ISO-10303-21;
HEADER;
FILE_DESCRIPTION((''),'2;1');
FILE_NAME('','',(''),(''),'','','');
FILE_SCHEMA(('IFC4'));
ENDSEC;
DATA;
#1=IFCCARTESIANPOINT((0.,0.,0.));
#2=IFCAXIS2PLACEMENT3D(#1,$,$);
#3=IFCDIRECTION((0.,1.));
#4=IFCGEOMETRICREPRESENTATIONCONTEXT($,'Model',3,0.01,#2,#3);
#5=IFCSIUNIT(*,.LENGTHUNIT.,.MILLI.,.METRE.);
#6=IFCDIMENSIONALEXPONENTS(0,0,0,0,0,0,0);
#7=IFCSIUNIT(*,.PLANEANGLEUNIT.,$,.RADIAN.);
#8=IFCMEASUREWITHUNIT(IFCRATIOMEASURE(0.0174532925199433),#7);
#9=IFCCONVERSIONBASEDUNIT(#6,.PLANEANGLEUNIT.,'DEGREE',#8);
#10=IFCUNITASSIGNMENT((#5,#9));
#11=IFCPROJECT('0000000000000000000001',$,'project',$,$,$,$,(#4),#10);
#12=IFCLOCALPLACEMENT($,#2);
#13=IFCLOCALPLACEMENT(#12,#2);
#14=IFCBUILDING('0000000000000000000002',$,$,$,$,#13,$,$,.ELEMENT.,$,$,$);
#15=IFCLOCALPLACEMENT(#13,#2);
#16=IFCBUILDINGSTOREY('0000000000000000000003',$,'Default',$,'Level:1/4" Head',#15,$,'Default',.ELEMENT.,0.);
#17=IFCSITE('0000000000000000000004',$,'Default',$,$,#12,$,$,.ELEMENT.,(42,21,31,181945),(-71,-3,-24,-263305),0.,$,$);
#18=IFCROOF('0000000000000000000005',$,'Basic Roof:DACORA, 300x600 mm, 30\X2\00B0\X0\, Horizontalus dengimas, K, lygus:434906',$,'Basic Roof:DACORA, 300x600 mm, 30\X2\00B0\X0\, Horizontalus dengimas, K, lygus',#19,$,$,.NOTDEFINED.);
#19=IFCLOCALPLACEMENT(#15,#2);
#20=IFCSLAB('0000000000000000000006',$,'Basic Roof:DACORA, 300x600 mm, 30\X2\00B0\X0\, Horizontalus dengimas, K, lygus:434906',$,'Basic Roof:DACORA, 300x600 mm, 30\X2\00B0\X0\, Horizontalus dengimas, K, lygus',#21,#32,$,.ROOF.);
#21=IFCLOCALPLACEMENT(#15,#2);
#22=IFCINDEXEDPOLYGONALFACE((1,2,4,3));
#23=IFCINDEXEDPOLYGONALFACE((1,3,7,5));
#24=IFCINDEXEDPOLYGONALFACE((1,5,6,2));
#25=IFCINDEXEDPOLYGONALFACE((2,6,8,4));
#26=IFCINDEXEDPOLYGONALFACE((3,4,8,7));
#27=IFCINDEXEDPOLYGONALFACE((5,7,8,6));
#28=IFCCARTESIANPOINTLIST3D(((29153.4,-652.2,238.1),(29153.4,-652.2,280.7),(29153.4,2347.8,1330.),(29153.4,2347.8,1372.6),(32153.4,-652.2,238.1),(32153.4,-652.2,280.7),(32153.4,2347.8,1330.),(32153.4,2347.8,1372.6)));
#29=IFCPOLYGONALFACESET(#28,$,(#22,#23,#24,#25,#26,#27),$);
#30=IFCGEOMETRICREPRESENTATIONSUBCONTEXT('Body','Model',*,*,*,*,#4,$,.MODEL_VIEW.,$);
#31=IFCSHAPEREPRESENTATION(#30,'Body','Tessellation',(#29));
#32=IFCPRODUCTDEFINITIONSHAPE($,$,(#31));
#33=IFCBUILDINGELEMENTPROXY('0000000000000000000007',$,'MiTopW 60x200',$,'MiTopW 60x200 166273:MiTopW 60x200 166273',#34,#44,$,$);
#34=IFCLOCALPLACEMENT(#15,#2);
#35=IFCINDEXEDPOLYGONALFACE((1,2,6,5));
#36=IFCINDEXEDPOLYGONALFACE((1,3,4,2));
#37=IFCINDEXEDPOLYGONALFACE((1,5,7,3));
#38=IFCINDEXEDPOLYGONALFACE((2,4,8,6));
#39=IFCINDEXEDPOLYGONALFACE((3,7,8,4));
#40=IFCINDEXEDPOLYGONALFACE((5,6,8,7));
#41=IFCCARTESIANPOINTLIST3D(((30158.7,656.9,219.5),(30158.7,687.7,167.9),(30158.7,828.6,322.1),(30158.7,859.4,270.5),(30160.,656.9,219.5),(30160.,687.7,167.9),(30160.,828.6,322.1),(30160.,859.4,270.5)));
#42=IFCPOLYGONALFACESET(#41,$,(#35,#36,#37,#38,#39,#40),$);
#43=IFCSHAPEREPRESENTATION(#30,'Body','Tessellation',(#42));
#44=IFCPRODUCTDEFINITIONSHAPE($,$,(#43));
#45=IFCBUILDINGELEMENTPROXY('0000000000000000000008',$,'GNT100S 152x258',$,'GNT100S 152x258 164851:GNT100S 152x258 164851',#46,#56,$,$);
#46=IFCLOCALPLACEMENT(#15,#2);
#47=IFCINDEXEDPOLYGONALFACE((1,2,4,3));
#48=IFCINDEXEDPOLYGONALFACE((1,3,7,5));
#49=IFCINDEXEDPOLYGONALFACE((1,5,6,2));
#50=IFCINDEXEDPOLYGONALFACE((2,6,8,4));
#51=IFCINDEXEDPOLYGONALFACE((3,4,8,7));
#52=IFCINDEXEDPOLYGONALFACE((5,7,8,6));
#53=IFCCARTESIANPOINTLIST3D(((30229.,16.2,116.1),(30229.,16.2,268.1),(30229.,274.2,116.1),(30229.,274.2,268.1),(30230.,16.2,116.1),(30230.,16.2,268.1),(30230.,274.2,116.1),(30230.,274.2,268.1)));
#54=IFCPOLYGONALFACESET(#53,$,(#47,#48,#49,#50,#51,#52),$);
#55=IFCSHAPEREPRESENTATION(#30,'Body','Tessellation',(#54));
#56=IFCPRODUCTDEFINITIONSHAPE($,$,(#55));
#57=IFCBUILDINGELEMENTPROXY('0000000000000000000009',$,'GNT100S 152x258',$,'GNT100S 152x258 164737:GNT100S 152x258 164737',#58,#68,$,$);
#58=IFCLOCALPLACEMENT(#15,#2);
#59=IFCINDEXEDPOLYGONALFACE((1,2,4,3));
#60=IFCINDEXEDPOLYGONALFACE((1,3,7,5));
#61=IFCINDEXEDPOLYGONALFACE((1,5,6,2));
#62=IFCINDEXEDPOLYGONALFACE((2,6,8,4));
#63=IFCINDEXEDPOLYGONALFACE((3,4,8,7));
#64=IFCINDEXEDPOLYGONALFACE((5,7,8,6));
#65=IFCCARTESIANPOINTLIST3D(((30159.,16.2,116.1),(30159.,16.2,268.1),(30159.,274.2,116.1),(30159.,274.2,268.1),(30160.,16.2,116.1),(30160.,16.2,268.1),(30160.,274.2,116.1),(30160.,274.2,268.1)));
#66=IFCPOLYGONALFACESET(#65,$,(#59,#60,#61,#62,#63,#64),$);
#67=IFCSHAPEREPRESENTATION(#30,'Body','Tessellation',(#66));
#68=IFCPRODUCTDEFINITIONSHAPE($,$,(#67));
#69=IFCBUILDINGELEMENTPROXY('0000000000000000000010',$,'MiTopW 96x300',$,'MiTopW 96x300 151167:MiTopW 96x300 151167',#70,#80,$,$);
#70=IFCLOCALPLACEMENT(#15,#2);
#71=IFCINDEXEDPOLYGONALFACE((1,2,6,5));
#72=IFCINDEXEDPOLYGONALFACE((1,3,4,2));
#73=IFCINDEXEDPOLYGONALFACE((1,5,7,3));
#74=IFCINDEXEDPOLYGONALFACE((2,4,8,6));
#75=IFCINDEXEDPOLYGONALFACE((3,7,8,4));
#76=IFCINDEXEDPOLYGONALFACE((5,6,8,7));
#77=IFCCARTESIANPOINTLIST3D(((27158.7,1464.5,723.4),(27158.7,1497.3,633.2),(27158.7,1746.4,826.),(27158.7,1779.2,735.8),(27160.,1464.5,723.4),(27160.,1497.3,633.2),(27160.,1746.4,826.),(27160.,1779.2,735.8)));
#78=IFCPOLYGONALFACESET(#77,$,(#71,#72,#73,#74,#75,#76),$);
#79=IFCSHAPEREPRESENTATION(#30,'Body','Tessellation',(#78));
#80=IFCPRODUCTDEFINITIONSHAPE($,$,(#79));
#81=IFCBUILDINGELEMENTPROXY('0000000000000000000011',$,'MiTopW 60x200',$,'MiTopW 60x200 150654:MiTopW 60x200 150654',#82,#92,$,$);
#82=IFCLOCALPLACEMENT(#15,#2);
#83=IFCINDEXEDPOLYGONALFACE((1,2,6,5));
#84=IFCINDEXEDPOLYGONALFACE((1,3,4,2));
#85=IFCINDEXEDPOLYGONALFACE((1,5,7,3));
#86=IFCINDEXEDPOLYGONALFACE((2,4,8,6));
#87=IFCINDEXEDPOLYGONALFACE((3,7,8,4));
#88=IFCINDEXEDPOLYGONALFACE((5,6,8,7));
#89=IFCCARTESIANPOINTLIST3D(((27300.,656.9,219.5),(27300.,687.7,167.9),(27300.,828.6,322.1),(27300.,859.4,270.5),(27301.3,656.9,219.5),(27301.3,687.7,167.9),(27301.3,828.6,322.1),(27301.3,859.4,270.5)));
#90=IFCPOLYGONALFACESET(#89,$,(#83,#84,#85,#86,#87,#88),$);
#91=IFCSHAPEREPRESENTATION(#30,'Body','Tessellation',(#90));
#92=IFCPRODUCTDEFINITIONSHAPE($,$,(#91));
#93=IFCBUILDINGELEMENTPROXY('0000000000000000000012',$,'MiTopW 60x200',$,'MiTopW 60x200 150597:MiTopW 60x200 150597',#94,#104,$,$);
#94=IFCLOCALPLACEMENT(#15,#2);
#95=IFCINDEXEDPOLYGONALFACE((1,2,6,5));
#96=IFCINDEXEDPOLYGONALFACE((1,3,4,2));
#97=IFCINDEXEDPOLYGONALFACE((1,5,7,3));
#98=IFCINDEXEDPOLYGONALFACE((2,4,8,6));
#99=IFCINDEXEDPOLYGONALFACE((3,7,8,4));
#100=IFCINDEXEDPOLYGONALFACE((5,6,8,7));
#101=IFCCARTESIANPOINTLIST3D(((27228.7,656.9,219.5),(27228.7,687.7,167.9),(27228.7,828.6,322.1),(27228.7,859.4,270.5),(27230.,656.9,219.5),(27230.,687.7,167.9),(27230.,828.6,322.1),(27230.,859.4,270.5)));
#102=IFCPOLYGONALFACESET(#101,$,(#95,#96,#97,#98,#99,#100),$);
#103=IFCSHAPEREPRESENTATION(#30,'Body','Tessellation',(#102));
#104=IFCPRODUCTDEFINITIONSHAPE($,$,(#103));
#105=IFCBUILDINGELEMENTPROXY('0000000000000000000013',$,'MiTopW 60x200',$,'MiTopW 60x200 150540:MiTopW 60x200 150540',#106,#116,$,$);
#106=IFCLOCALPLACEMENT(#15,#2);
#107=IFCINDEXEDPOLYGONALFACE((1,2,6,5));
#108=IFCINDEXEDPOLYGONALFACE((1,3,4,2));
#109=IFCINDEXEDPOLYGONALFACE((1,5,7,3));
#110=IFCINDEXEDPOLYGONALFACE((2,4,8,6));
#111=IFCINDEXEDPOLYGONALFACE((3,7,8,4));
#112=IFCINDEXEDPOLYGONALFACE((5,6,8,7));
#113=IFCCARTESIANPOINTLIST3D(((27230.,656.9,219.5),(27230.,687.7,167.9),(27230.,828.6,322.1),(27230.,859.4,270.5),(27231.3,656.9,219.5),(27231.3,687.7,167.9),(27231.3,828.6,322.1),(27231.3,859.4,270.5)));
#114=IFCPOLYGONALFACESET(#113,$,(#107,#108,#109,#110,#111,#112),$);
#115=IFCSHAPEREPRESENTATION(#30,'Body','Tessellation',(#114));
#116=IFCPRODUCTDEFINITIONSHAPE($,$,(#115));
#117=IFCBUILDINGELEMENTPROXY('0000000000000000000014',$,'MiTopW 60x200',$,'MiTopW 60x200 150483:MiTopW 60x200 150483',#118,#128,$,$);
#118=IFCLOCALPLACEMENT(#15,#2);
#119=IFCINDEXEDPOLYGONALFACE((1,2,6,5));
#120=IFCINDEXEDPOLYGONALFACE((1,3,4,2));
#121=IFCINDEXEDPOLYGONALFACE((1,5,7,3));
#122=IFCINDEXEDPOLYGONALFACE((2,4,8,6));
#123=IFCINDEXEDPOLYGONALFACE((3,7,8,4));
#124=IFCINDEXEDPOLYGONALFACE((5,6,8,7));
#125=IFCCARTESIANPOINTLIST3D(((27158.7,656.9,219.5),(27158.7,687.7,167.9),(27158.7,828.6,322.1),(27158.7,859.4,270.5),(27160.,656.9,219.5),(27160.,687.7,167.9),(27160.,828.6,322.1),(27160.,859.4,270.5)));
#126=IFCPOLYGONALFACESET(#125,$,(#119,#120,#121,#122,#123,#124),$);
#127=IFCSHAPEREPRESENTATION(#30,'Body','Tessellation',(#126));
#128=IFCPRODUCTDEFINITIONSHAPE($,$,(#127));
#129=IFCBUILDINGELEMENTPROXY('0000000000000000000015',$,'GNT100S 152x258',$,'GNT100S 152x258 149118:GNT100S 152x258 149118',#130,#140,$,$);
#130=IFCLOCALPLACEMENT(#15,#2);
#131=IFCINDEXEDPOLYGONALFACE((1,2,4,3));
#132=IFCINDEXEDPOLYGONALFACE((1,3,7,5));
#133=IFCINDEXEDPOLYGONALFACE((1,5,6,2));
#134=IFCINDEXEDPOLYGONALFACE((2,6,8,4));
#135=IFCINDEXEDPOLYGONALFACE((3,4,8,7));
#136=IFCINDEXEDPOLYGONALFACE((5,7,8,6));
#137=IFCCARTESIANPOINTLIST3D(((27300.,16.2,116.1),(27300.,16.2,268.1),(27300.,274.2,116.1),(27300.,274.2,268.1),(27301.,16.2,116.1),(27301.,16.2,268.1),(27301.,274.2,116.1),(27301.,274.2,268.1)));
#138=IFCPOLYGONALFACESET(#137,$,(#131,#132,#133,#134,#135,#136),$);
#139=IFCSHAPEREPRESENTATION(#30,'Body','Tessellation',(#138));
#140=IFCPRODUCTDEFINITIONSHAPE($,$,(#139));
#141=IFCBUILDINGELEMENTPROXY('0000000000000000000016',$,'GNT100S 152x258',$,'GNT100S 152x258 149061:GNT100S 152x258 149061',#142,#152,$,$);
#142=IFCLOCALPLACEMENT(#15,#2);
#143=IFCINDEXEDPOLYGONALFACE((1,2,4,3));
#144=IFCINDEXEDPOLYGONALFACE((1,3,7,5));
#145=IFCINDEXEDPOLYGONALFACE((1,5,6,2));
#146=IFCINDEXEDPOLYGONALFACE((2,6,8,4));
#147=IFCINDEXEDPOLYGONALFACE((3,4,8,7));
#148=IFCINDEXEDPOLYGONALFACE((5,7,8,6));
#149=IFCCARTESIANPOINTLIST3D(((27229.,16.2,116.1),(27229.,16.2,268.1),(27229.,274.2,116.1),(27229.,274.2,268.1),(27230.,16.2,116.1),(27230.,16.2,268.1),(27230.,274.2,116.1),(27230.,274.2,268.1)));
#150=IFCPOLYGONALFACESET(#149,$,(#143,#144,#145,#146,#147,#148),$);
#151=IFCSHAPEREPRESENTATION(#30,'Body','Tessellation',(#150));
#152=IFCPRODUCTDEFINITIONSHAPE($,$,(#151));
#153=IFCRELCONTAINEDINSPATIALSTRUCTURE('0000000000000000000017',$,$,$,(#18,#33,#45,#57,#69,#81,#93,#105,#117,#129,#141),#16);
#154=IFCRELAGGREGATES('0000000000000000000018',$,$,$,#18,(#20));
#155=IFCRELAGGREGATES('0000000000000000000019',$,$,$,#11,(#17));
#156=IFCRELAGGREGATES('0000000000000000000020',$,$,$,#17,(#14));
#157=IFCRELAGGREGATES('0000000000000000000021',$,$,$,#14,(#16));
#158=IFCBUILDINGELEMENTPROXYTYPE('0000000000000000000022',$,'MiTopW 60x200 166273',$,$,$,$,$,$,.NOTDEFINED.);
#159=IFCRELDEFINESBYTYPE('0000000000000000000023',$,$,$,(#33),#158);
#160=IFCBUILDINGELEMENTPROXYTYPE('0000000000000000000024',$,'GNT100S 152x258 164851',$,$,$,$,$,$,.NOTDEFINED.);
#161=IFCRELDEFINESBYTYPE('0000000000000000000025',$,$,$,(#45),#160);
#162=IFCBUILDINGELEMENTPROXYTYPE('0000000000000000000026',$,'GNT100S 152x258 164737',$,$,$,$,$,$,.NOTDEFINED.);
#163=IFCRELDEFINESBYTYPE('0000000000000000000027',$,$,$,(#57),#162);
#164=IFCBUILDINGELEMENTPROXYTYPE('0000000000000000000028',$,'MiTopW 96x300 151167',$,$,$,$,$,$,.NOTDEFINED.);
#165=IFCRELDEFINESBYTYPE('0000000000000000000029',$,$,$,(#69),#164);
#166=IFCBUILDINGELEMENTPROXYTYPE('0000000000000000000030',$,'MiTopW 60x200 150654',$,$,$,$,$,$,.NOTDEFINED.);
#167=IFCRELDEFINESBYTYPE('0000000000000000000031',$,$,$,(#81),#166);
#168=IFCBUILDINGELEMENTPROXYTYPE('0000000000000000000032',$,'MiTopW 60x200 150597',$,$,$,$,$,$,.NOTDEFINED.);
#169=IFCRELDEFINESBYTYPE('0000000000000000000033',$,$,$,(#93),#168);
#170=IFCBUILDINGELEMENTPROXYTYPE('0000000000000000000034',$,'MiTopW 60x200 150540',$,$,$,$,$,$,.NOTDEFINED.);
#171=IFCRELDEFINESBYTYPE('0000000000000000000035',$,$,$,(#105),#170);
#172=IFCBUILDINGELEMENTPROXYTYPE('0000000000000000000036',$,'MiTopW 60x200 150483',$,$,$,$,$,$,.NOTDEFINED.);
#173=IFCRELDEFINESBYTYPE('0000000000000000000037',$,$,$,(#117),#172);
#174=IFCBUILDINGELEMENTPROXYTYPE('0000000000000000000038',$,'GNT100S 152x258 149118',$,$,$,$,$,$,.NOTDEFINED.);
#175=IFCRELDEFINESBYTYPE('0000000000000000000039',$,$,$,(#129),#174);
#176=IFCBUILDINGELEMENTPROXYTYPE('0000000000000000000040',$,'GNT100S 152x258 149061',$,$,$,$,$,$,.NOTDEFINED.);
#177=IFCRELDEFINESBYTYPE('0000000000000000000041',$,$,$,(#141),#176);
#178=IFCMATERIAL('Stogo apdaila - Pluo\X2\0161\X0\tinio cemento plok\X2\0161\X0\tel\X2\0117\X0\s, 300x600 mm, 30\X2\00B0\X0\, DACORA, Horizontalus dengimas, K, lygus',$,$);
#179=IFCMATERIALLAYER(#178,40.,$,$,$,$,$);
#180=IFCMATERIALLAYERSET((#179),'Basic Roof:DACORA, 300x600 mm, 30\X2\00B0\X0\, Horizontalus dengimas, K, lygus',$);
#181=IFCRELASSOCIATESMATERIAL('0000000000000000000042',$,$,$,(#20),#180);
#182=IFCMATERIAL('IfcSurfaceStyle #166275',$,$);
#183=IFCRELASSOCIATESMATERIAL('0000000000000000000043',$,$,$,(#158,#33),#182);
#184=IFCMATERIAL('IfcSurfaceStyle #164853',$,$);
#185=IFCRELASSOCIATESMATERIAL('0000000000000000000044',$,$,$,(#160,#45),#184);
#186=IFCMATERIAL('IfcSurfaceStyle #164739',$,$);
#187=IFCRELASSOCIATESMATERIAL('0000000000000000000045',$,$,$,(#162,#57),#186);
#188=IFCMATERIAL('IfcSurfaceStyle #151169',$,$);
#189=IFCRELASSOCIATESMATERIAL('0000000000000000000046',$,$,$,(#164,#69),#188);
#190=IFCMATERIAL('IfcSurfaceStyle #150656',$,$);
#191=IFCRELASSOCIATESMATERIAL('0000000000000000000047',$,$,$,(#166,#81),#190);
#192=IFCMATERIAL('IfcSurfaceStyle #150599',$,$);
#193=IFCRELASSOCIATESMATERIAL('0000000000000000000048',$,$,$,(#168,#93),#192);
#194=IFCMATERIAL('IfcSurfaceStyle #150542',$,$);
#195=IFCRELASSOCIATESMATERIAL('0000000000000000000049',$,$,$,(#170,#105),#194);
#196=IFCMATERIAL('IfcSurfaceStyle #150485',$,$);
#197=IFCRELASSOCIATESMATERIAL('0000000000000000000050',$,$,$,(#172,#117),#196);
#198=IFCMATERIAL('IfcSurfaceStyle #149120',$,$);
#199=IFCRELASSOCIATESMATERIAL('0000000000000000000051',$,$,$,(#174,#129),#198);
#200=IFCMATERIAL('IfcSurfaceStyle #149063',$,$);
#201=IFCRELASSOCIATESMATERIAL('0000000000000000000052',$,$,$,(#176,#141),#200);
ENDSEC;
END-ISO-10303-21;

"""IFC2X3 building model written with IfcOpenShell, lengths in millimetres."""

from ifc_helpers import new_model, entity, si_unit, converted_unit, direction, frame, frame_2d, origin, origin_2d_with_axis, place, context, subcontext, project, spatial, polyline, rectangle, outline, extrude, source, transform, mapped, material, layer, layer_set, type_object, type_shapes, element, aggregate, save


model = new_model("IFC2X3")

# Units and contexts
model_context = context("Model", 3, precision=0.01, world=origin(), true_north=direction((0.0, 1.0)))
body_context = subcontext(model_context, "Body", "Model", "MODEL_VIEW")
ifc_project = project(units=[si_unit("LENGTHUNIT", "METRE", prefix="MILLI"), converted_unit("PLANEANGLEUNIT", "DEGREE", entity("IfcRatioMeasure", 0.0174532925199433), si_unit("PLANEANGLEUNIT", "RADIAN"), dimensions=[0, 0, 0, 0, 0, 0, 0])], contexts=[model_context])

# Site, building, storey
site_placement = place(None, origin())
site = spatial("IfcSite", under=ifc_project, at=site_placement, Name="Default", CompositionType="ELEMENT", RefLatitude=(42, 21, 31, 181945), RefLongitude=(-71, -3, -24, -263305), RefElevation=0.0)
building_placement = place(site_placement, origin())
building = spatial("IfcBuilding", under=site, at=building_placement, CompositionType="ELEMENT")
storey_placement = place(building_placement, origin())
storey = spatial("IfcBuildingStorey", under=building, at=storey_placement, Name="Default", ObjectType="Level:1/4\" Head", LongName="Default", CompositionType="ELEMENT", Elevation=0.0)

# Roof, slab
roof_placement = place(storey_placement, frame((29153.4, -652.2, 238.1)))
roof = element("IfcRoof", 1, at=roof_placement, inside=storey, Name="Basic Roof:DACORA, 300x600 mm, 30°, Horizontalus dengimas, K, lygus:434906", ObjectType="Basic Roof:DACORA, 300x600 mm, 30°, Horizontalus dengimas, K, lygus", ShapeType="NOTDEFINED")
ifc_material_1 = material(Name="Stogo apdaila - Pluoštinio cemento plokštelės, 300x600 mm, 30°, DACORA, Horizontalus dengimas, K, lygus")
ifc_layer = layer(ifc_material_1, 40.0)
ifc_layer_set = layer_set([ifc_layer], Name="Basic Roof:DACORA, 300x600 mm, 30°, Horizontalus dengimas, K, lygus")
slab_placement = place(roof_placement, origin())
slab = element("IfcSlab", 2, at=slab_placement, material=ifc_layer_set, Name="Basic Roof:DACORA, 300x600 mm, 30°, Horizontalus dengimas, K, lygus:434906", ObjectType="Basic Roof:DACORA, 300x600 mm, 30°, Horizontalus dengimas, K, lygus", PredefinedType="ROOF", context=body_context, shape_type="SweptSolid", body=[
    extrude(rectangle(XDim=3192.5, YDim=3000.0, at=frame_2d((0.0, 0.0), x_axis=(0.0, -1.0))), frame((1500.0, 1500.0, 546.0), z_axis=(0.0, -0.34202, 0.939693), x_axis=(1.0, 0.0, 0.0)), (0.0, 0.34202, 0.939693), 42.6),
])
aggregate(roof, [slab])

# Building element proxies
ifc_material_2 = material(Name="IfcSurfaceStyle #166275")
building_element_proxy_type_1 = type_object("IfcBuildingElementProxyType", Name="MiTopW 60x200 166273", PredefinedType="NOTDEFINED", material=ifc_material_2)
shared_shape_1 = source(origin(), body_context, "Body", "SweptSolid", [
    extrude(outline(polyline([(-100.0, -30.0), (100.0, -30.0), (100.0, 30.0), (-100.0, 30.0), (-100.0, -30.0)])), frame((100.0, 30.0, 0.0), z_axis=(0.0, 0.0, 1.0), x_axis=(-1.0, 0.0, 0.0)), (0.0, 0.0, 1.0), 1.3),
])
type_shapes(building_element_proxy_type_1, [shared_shape_1])
proxy_1_placement = place(building_placement, frame((30160.0, 656.9, 219.5), z_axis=(-1.0, 0.0, 0.0), x_axis=(0.0, 0.858392, 0.512994)))
element("IfcBuildingElementProxy", 3, at=proxy_1_placement, inside=storey, type_object=building_element_proxy_type_1, material=ifc_material_2, Name="MiTopW 60x200", ObjectType="MiTopW 60x200 166273:MiTopW 60x200 166273", context=body_context, shape_type="MappedRepresentation", body=[
    mapped(shared_shape_1, transform((0.0, 0.0, 0.0), scale=1.0)),
])
ifc_material_3 = material(Name="IfcSurfaceStyle #164853")
building_element_proxy_type_2 = type_object("IfcBuildingElementProxyType", Name="GNT100S 152x258 164851", PredefinedType="NOTDEFINED", material=ifc_material_3)
shared_shape_2 = source(origin(), body_context, "Body", "SweptSolid", [
    extrude(rectangle(XDim=258.0, YDim=152.0, at=origin_2d_with_axis()), frame((129.0, 76.0, 0.0), z_axis=(0.0, 0.0, 1.0), x_axis=(-1.0, 0.0, 0.0)), (0.0, 0.0, 1.0), 1.0),
])
type_shapes(building_element_proxy_type_2, [shared_shape_2])
proxy_2_placement = place(building_placement, frame((30230.0, 16.2, 268.1), z_axis=(-1.0, 0.0, 0.0), x_axis=(0.0, 1.0, 0.0)))
element("IfcBuildingElementProxy", 4, at=proxy_2_placement, inside=storey, type_object=building_element_proxy_type_2, material=ifc_material_3, Name="GNT100S 152x258", ObjectType="GNT100S 152x258 164851:GNT100S 152x258 164851", context=body_context, shape_type="MappedRepresentation", body=[
    mapped(shared_shape_2, transform((0.0, 0.0, 0.0), scale=1.0)),
])
ifc_material_4 = material(Name="IfcSurfaceStyle #164739")
building_element_proxy_type_3 = type_object("IfcBuildingElementProxyType", Name="GNT100S 152x258 164737", PredefinedType="NOTDEFINED", material=ifc_material_4)
shared_shape_3 = source(origin(), body_context, "Body", "SweptSolid", [
    extrude(rectangle(XDim=258.0, YDim=152.0, at=origin_2d_with_axis()), frame((129.0, 76.0, 0.0), z_axis=(0.0, 0.0, 1.0), x_axis=(-1.0, 0.0, 0.0)), (0.0, 0.0, 1.0), 1.0),
])
type_shapes(building_element_proxy_type_3, [shared_shape_3])
proxy_3_placement = place(building_placement, frame((30160.0, 16.2, 268.1), z_axis=(-1.0, 0.0, 0.0), x_axis=(0.0, 1.0, 0.0)))
element("IfcBuildingElementProxy", 5, at=proxy_3_placement, inside=storey, type_object=building_element_proxy_type_3, material=ifc_material_4, Name="GNT100S 152x258", ObjectType="GNT100S 152x258 164737:GNT100S 152x258 164737", context=body_context, shape_type="MappedRepresentation", body=[
    mapped(shared_shape_3, transform((0.0, 0.0, 0.0), scale=1.0)),
])
ifc_material_5 = material(Name="IfcSurfaceStyle #151169")
building_element_proxy_type_4 = type_object("IfcBuildingElementProxyType", Name="MiTopW 96x300 151167", PredefinedType="NOTDEFINED", material=ifc_material_5)
shared_shape_4 = source(origin(), body_context, "Body", "SweptSolid", [
    extrude(outline(polyline([(-150.0, -48.0), (150.0, -48.0), (150.0, 48.0), (-150.0, 48.0), (-150.0, -48.0)])), frame((150.0, 48.0, 0.0), z_axis=(0.0, 0.0, 1.0), x_axis=(-1.0, 0.0, 0.0)), (0.0, 0.0, 1.0), 1.3),
])
type_shapes(building_element_proxy_type_4, [shared_shape_4])
proxy_4_placement = place(building_placement, frame((27160.0, 1464.5, 723.4), z_axis=(-1.0, 0.0, 0.0), x_axis=(0.0, 0.939693, 0.34202)))
element("IfcBuildingElementProxy", 6, at=proxy_4_placement, inside=storey, type_object=building_element_proxy_type_4, material=ifc_material_5, Name="MiTopW 96x300", ObjectType="MiTopW 96x300 151167:MiTopW 96x300 151167", context=body_context, shape_type="MappedRepresentation", body=[
    mapped(shared_shape_4, transform((0.0, 0.0, 0.0), scale=1.0)),
])
ifc_material_6 = material(Name="IfcSurfaceStyle #150656")
building_element_proxy_type_5 = type_object("IfcBuildingElementProxyType", Name="MiTopW 60x200 150654", PredefinedType="NOTDEFINED", material=ifc_material_6)
shared_shape_5 = source(origin(), body_context, "Body", "SweptSolid", [
    extrude(outline(polyline([(-100.0, -30.0), (100.0, -30.0), (100.0, 30.0), (-100.0, 30.0), (-100.0, -30.0)])), frame((100.0, 30.0, 0.0), z_axis=(0.0, 0.0, 1.0), x_axis=(-1.0, 0.0, 0.0)), (0.0, 0.0, 1.0), 1.3),
])
type_shapes(building_element_proxy_type_5, [shared_shape_5])
proxy_5_placement = place(building_placement, frame((27301.3, 656.9, 219.5), z_axis=(-1.0, 0.0, 0.0), x_axis=(0.0, 0.858392, 0.512994)))
element("IfcBuildingElementProxy", 7, at=proxy_5_placement, inside=storey, type_object=building_element_proxy_type_5, material=ifc_material_6, Name="MiTopW 60x200", ObjectType="MiTopW 60x200 150654:MiTopW 60x200 150654", context=body_context, shape_type="MappedRepresentation", body=[
    mapped(shared_shape_5, transform((0.0, 0.0, 0.0), scale=1.0)),
])
ifc_material_7 = material(Name="IfcSurfaceStyle #150599")
building_element_proxy_type_6 = type_object("IfcBuildingElementProxyType", Name="MiTopW 60x200 150597", PredefinedType="NOTDEFINED", material=ifc_material_7)
shared_shape_6 = source(origin(), body_context, "Body", "SweptSolid", [
    extrude(outline(polyline([(-100.0, -30.0), (100.0, -30.0), (100.0, 30.0), (-100.0, 30.0), (-100.0, -30.0)])), frame((100.0, 30.0, 0.0), z_axis=(0.0, 0.0, 1.0), x_axis=(-1.0, 0.0, 0.0)), (0.0, 0.0, 1.0), 1.3),
])
type_shapes(building_element_proxy_type_6, [shared_shape_6])
proxy_6_placement = place(building_placement, frame((27230.0, 656.9, 219.5), z_axis=(-1.0, 0.0, 0.0), x_axis=(0.0, 0.858392, 0.512994)))
element("IfcBuildingElementProxy", 8, at=proxy_6_placement, inside=storey, type_object=building_element_proxy_type_6, material=ifc_material_7, Name="MiTopW 60x200", ObjectType="MiTopW 60x200 150597:MiTopW 60x200 150597", context=body_context, shape_type="MappedRepresentation", body=[
    mapped(shared_shape_6, transform((0.0, 0.0, 0.0), scale=1.0)),
])
ifc_material_8 = material(Name="IfcSurfaceStyle #150542")
building_element_proxy_type_7 = type_object("IfcBuildingElementProxyType", Name="MiTopW 60x200 150540", PredefinedType="NOTDEFINED", material=ifc_material_8)
shared_shape_7 = source(origin(), body_context, "Body", "SweptSolid", [
    extrude(outline(polyline([(-100.0, -30.0), (100.0, -30.0), (100.0, 30.0), (-100.0, 30.0), (-100.0, -30.0)])), frame((100.0, 30.0, 0.0), z_axis=(0.0, 0.0, 1.0), x_axis=(-1.0, 0.0, 0.0)), (0.0, 0.0, 1.0), 1.3),
])
type_shapes(building_element_proxy_type_7, [shared_shape_7])
proxy_7_placement = place(building_placement, frame((27231.3, 656.9, 219.5), z_axis=(-1.0, 0.0, 0.0), x_axis=(0.0, 0.858392, 0.512994)))
element("IfcBuildingElementProxy", 9, at=proxy_7_placement, inside=storey, type_object=building_element_proxy_type_7, material=ifc_material_8, Name="MiTopW 60x200", ObjectType="MiTopW 60x200 150540:MiTopW 60x200 150540", context=body_context, shape_type="MappedRepresentation", body=[
    mapped(shared_shape_7, transform((0.0, 0.0, 0.0), scale=1.0)),
])
ifc_material_9 = material(Name="IfcSurfaceStyle #150485")
building_element_proxy_type_8 = type_object("IfcBuildingElementProxyType", Name="MiTopW 60x200 150483", PredefinedType="NOTDEFINED", material=ifc_material_9)
shared_shape_8 = source(origin(), body_context, "Body", "SweptSolid", [
    extrude(outline(polyline([(-100.0, -30.0), (100.0, -30.0), (100.0, 30.0), (-100.0, 30.0), (-100.0, -30.0)])), frame((100.0, 30.0, 0.0), z_axis=(0.0, 0.0, 1.0), x_axis=(-1.0, 0.0, 0.0)), (0.0, 0.0, 1.0), 1.3),
])
type_shapes(building_element_proxy_type_8, [shared_shape_8])
proxy_8_placement = place(building_placement, frame((27160.0, 656.9, 219.5), z_axis=(-1.0, 0.0, 0.0), x_axis=(0.0, 0.858392, 0.512994)))
element("IfcBuildingElementProxy", 10, at=proxy_8_placement, inside=storey, type_object=building_element_proxy_type_8, material=ifc_material_9, Name="MiTopW 60x200", ObjectType="MiTopW 60x200 150483:MiTopW 60x200 150483", context=body_context, shape_type="MappedRepresentation", body=[
    mapped(shared_shape_8, transform((0.0, 0.0, 0.0), scale=1.0)),
])
ifc_material_10 = material(Name="IfcSurfaceStyle #149120")
building_element_proxy_type_9 = type_object("IfcBuildingElementProxyType", Name="GNT100S 152x258 149118", PredefinedType="NOTDEFINED", material=ifc_material_10)
shared_shape_9 = source(origin(), body_context, "Body", "SweptSolid", [
    extrude(rectangle(XDim=258.0, YDim=152.0, at=origin_2d_with_axis()), frame((129.0, 76.0, 0.0), z_axis=(0.0, 0.0, 1.0), x_axis=(-1.0, 0.0, 0.0)), (0.0, 0.0, 1.0), 1.0),
])
type_shapes(building_element_proxy_type_9, [shared_shape_9])
proxy_9_placement = place(building_placement, frame((27301.0, 16.2, 268.1), z_axis=(-1.0, 0.0, 0.0), x_axis=(0.0, 1.0, 0.0)))
element("IfcBuildingElementProxy", 11, at=proxy_9_placement, inside=storey, type_object=building_element_proxy_type_9, material=ifc_material_10, Name="GNT100S 152x258", ObjectType="GNT100S 152x258 149118:GNT100S 152x258 149118", context=body_context, shape_type="MappedRepresentation", body=[
    mapped(shared_shape_9, transform((0.0, 0.0, 0.0), scale=1.0)),
])
ifc_material_11 = material(Name="IfcSurfaceStyle #149063")
building_element_proxy_type_10 = type_object("IfcBuildingElementProxyType", Name="GNT100S 152x258 149061", PredefinedType="NOTDEFINED", material=ifc_material_11)
shared_shape_10 = source(origin(), body_context, "Body", "SweptSolid", [
    extrude(rectangle(XDim=258.0, YDim=152.0, at=origin_2d_with_axis()), frame((129.0, 76.0, 0.0), z_axis=(0.0, 0.0, 1.0), x_axis=(-1.0, 0.0, 0.0)), (0.0, 0.0, 1.0), 1.0),
])
type_shapes(building_element_proxy_type_10, [shared_shape_10])
proxy_10_placement = place(building_placement, frame((27230.0, 16.2, 268.1), z_axis=(-1.0, 0.0, 0.0), x_axis=(0.0, 1.0, 0.0)))
element("IfcBuildingElementProxy", 12, at=proxy_10_placement, inside=storey, type_object=building_element_proxy_type_10, material=ifc_material_11, Name="GNT100S 152x258", ObjectType="GNT100S 152x258 149061:GNT100S 152x258 149061", context=body_context, shape_type="MappedRepresentation", body=[
    mapped(shared_shape_10, transform((0.0, 0.0, 0.0), scale=1.0)),
])

save(model, "model.ifc")
